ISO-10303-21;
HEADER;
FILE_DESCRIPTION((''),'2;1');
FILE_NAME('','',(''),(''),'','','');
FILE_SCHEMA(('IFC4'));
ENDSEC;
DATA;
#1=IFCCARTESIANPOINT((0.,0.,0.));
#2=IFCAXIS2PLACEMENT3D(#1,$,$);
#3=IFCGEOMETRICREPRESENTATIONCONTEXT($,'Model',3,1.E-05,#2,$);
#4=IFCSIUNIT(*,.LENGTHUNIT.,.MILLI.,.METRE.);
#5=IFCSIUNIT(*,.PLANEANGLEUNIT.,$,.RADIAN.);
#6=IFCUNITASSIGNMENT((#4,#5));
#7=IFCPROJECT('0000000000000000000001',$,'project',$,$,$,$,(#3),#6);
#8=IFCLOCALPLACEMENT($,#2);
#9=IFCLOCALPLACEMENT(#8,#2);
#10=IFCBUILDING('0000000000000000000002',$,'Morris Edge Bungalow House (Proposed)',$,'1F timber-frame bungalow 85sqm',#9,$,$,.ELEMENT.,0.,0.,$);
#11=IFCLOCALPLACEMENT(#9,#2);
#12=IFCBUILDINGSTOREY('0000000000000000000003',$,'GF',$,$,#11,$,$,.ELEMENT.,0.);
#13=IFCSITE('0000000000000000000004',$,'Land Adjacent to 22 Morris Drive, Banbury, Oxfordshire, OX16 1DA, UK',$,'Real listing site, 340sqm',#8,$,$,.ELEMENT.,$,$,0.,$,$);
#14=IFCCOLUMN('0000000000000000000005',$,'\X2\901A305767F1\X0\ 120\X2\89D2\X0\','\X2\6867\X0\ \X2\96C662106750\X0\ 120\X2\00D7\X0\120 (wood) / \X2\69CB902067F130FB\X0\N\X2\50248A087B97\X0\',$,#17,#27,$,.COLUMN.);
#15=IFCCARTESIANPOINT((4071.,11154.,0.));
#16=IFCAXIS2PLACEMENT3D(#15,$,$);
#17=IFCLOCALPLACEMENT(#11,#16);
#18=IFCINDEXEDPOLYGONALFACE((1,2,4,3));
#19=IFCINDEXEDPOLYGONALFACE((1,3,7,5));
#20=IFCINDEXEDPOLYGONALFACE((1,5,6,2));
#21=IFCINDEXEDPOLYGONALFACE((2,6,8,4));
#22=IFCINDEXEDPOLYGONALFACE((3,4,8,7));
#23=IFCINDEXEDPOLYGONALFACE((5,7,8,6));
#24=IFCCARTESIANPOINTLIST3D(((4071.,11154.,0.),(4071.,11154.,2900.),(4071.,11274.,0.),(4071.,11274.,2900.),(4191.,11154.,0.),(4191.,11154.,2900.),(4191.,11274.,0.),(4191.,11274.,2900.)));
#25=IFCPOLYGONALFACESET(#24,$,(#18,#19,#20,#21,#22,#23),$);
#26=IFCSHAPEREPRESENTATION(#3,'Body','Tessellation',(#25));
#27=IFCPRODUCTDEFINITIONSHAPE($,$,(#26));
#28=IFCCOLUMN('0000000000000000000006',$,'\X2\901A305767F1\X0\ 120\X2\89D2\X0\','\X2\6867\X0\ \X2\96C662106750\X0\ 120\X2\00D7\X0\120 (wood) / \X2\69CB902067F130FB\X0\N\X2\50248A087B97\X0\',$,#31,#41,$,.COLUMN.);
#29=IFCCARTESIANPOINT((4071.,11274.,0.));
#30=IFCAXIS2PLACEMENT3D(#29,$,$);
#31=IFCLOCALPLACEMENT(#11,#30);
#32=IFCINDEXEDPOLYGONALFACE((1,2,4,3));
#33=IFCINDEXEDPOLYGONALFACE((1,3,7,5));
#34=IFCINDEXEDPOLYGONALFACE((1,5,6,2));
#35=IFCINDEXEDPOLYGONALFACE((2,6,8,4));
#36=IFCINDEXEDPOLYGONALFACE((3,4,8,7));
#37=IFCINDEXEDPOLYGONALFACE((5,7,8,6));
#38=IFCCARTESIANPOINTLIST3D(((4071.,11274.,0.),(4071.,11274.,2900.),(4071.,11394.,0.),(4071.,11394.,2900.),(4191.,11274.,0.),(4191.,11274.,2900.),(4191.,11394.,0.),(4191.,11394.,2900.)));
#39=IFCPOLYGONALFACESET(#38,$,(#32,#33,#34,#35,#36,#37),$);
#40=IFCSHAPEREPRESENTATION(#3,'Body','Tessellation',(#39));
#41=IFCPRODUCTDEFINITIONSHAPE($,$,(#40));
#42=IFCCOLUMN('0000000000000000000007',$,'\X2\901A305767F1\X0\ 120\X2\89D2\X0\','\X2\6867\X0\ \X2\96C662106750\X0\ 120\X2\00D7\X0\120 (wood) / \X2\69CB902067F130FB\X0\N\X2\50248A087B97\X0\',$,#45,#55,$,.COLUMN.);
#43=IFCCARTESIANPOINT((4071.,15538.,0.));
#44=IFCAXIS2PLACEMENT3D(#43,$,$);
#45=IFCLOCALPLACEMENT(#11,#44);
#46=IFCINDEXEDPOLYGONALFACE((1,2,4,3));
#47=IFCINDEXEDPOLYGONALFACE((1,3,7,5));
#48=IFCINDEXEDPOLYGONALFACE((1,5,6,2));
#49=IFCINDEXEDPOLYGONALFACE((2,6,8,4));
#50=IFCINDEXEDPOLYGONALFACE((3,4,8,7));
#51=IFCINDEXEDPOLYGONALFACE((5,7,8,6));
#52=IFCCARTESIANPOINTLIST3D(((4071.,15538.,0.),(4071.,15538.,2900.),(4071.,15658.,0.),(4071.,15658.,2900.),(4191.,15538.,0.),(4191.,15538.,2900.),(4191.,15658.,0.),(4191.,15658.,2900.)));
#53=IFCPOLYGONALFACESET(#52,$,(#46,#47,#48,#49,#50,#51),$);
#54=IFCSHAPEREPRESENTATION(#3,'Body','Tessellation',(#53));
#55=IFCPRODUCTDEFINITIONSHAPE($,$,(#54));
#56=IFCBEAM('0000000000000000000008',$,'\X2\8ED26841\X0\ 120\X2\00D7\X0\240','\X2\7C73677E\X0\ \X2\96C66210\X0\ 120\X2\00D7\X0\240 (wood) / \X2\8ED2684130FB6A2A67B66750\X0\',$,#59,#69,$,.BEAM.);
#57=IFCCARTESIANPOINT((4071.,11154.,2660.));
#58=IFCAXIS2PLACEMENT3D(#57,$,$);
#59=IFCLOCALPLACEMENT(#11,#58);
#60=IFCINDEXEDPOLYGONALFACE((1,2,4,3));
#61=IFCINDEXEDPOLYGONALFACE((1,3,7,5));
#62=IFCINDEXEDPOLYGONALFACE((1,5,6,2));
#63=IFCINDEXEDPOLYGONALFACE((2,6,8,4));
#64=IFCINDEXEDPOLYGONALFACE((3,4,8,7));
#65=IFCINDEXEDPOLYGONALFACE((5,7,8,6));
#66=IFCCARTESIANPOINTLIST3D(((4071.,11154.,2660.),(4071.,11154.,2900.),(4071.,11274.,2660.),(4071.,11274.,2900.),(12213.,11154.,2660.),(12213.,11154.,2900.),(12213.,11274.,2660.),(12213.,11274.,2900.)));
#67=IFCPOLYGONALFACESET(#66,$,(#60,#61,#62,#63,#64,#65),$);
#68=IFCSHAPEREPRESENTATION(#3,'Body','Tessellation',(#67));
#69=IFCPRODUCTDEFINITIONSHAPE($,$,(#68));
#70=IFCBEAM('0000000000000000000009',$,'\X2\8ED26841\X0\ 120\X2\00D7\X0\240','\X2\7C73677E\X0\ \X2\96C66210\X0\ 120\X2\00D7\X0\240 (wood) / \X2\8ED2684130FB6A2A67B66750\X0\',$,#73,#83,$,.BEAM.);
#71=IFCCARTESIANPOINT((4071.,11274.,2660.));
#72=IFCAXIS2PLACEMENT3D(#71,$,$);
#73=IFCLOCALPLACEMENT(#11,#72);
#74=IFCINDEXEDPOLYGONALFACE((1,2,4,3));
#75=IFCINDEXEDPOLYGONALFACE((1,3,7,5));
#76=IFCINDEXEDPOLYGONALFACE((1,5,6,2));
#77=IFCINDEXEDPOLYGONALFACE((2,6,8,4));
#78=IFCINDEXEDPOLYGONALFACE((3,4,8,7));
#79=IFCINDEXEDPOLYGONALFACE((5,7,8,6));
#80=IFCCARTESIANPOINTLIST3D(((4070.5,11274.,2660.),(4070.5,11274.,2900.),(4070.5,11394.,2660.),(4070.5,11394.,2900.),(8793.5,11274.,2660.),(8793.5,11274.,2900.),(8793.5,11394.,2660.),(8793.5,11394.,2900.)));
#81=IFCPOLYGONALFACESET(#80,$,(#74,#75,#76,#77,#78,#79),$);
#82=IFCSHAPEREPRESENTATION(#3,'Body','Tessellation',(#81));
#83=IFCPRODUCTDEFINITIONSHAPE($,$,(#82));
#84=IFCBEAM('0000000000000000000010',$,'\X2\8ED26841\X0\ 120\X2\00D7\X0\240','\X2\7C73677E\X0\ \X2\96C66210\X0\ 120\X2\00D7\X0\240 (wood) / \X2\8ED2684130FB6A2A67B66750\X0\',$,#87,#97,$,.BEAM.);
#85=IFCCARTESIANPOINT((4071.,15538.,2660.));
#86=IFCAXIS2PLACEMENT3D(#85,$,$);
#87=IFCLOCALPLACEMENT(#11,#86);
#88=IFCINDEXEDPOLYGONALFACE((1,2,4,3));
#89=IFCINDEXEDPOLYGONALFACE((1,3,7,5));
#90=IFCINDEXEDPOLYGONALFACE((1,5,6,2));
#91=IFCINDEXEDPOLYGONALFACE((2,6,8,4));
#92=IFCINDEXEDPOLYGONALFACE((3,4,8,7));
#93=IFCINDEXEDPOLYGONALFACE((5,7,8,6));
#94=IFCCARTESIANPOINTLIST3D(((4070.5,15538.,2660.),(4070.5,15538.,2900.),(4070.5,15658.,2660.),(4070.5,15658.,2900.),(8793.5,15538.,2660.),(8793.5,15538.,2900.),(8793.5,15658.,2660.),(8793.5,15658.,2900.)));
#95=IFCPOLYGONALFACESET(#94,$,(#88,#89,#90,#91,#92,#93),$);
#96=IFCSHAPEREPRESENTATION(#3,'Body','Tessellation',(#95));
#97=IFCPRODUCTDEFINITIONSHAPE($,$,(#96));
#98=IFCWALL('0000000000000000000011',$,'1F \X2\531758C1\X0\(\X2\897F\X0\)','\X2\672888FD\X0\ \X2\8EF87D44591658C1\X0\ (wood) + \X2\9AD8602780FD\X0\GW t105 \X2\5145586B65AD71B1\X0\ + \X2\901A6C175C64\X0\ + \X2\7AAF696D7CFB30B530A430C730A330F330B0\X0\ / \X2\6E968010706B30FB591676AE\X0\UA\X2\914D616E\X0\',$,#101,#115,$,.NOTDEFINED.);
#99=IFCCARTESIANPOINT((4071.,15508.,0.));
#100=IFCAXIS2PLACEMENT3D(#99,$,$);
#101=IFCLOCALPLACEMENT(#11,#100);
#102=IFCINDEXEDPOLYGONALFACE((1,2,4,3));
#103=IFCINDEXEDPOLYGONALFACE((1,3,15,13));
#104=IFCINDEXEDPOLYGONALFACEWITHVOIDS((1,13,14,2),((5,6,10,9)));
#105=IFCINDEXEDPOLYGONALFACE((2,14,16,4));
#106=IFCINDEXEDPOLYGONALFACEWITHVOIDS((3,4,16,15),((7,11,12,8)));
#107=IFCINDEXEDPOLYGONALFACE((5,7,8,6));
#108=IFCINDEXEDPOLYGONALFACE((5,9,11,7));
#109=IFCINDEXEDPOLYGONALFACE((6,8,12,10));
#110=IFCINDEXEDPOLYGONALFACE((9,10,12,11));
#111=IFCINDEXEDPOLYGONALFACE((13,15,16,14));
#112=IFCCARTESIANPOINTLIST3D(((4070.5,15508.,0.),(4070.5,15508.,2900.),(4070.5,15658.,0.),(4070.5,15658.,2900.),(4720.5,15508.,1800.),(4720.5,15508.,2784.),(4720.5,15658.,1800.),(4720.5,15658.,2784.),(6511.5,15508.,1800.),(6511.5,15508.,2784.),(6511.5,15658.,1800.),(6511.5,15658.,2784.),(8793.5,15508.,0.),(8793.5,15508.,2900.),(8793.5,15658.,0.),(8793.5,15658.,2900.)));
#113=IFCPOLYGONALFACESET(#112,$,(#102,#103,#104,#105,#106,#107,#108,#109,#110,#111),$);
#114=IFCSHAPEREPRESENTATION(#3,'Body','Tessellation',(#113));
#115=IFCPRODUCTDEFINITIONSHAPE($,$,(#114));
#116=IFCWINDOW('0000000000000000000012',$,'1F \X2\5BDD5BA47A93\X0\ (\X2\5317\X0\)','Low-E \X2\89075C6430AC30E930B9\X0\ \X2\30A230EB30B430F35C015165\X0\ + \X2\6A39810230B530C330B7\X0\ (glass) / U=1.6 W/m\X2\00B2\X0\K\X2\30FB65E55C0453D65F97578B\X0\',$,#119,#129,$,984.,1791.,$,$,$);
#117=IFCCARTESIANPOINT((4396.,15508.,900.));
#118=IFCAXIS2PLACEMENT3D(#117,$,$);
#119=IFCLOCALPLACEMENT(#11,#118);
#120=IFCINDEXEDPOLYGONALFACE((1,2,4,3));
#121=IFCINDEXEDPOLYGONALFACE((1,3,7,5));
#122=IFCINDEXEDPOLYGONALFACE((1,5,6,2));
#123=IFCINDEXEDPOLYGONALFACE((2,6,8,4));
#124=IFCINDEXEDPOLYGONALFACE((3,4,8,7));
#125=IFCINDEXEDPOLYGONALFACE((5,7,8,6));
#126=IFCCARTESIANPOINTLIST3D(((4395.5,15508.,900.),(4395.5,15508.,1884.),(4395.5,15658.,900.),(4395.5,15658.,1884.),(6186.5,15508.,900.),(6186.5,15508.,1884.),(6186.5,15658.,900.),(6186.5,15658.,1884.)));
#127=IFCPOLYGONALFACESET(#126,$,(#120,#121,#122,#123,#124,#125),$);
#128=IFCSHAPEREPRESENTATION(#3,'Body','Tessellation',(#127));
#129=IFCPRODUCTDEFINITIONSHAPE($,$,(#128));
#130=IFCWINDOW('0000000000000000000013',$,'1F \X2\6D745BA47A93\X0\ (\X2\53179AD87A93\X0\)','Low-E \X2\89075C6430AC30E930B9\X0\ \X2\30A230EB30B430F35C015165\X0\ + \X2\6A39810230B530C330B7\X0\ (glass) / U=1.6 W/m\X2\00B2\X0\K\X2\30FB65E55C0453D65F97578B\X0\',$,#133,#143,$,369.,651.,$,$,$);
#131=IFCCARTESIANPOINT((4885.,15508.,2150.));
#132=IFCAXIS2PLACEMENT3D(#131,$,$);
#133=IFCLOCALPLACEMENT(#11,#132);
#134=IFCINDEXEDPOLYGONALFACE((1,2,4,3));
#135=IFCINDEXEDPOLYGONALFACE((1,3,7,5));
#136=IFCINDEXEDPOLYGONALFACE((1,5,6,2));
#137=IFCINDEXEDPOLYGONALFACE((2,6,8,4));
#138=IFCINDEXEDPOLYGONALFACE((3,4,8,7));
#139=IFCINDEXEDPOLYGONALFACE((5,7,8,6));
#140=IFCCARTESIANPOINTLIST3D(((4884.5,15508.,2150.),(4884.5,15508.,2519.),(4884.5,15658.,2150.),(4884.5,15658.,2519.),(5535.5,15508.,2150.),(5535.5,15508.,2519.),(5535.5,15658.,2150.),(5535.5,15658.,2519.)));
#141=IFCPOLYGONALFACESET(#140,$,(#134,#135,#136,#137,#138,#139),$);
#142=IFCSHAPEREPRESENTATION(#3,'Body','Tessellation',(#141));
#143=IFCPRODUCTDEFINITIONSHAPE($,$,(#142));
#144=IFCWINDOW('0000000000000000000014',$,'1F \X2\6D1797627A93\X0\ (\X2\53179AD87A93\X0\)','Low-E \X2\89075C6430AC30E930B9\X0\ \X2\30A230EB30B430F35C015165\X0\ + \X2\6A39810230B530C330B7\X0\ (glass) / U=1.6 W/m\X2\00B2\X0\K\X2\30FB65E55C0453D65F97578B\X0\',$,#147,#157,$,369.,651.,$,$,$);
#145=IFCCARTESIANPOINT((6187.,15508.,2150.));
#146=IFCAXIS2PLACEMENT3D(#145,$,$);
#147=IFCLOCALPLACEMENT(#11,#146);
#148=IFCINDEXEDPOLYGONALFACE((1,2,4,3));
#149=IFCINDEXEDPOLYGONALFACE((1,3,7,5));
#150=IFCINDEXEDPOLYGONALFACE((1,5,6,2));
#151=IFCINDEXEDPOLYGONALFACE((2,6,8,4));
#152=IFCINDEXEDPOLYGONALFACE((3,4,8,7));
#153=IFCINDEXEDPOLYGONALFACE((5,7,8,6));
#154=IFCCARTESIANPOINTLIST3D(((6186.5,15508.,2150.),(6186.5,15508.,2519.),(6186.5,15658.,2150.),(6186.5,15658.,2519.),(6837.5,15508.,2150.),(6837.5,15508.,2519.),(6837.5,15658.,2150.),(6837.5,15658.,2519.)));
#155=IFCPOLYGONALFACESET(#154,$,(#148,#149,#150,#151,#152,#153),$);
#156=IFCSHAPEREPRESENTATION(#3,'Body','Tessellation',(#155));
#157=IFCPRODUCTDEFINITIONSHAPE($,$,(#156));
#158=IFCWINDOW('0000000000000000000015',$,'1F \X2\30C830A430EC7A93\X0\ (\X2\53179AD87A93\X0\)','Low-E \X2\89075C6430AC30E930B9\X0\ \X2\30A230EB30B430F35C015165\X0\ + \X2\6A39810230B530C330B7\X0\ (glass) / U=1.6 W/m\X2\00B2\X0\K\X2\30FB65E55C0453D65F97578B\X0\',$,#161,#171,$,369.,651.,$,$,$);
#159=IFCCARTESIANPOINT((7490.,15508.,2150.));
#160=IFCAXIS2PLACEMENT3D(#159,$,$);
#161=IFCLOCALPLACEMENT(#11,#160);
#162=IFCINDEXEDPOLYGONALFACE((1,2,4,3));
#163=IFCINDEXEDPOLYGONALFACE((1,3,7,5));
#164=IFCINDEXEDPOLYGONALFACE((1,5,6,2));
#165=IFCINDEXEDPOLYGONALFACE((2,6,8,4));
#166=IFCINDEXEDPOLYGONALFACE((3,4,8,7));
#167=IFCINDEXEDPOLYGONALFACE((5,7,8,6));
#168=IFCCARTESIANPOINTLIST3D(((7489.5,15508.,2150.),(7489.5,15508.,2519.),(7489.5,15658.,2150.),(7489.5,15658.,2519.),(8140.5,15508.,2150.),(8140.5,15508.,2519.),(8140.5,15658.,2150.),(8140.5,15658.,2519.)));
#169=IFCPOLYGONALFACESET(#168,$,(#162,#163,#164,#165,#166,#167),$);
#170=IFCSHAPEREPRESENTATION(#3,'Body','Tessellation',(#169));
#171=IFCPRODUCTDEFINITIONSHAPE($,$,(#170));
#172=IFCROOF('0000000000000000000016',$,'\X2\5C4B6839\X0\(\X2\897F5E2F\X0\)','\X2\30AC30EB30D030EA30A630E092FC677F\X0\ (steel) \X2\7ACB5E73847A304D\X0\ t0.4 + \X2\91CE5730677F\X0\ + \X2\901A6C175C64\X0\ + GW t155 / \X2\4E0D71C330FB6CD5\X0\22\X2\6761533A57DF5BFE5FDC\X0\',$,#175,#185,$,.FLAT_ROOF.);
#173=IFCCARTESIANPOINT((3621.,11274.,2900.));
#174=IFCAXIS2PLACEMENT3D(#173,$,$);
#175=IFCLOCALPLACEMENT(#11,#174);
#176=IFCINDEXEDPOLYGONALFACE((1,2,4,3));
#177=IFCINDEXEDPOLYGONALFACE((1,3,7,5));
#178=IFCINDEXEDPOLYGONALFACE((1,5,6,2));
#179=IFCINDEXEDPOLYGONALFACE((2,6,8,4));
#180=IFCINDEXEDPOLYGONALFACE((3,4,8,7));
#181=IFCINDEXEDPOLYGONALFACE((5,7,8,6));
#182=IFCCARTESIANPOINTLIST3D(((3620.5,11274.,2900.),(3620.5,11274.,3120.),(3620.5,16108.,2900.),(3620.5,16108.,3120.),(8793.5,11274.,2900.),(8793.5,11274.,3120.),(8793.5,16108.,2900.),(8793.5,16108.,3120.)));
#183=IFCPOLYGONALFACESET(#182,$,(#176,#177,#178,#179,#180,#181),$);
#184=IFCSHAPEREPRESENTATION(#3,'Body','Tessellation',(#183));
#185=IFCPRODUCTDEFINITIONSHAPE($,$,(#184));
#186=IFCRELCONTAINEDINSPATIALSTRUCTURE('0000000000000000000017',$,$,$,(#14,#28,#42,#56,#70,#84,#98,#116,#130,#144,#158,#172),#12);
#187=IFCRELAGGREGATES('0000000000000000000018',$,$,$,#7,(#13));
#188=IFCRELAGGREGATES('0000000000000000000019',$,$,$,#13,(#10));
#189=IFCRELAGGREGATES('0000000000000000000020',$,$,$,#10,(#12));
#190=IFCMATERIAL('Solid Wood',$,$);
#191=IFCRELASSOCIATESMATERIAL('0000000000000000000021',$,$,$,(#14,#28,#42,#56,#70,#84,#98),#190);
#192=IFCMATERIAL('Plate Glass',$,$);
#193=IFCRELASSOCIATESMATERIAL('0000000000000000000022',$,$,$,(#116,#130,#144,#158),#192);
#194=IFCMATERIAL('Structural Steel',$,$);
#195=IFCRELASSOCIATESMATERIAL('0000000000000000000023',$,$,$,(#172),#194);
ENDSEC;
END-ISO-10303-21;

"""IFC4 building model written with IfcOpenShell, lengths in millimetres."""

from ifc_helpers import new_model, si_unit, frame, frame_2d, origin, place, context, project, spatial, rectangle, extrude, material, element, fill, save


model = new_model("IFC4")

# Units and contexts
model_context = context("Model", 3, precision=1e-05, world=origin())
ifc_project = project(units=[si_unit("LENGTHUNIT", "METRE", prefix="MILLI"), si_unit("PLANEANGLEUNIT", "RADIAN")], contexts=[model_context])

# Site, building, storey
site_placement = place(None, origin())
site = spatial("IfcSite", under=ifc_project, at=site_placement, Name="Land Adjacent to 22 Morris Drive, Banbury, Oxfordshire, OX16 1DA, UK", ObjectType="Real listing site, 340sqm", CompositionType="ELEMENT", RefElevation=0.0)
building_placement = place(site_placement, origin())
building = spatial("IfcBuilding", under=site, at=building_placement, Name="Morris Edge Bungalow House (Proposed)", ObjectType="1F timber-frame bungalow 85sqm", CompositionType="ELEMENT", ElevationOfRefHeight=0.0, ElevationOfTerrain=0.0)
storey_placement = place(building_placement, origin())
storey = spatial("IfcBuildingStorey", under=building, at=storey_placement, Name="GF", CompositionType="ELEMENT", Elevation=0.0)

# Columns
ifc_material_1 = material(Name="Solid Wood")
column_1_placement = place(storey_placement, frame((4071.0, 11154.0, 0.0)))
element("IfcColumn", 1, at=column_1_placement, inside=storey, material=ifc_material_1, Name="通し柱 120角", Description="桧 集成材 120×120 (wood) / 構造柱・N値計算", PredefinedType="COLUMN", context=model_context, shape_type="SweptSolid", body=[
    extrude(rectangle(XDim=120.0, YDim=120.0, at=frame_2d((60.0, 60.0))), frame((4071.0, 11154.0, 0.0)), (0.0, 0.0, 1.0), 2900.0),
])
column_2_placement = place(storey_placement, frame((4071.0, 11274.0, 0.0)))
element("IfcColumn", 2, at=column_2_placement, inside=storey, material=ifc_material_1, Name="通し柱 120角", Description="桧 集成材 120×120 (wood) / 構造柱・N値計算", PredefinedType="COLUMN", context=model_context, shape_type="SweptSolid", body=[
    extrude(rectangle(XDim=120.0, YDim=120.0, at=frame_2d((60.0, 60.0))), frame((4071.0, 11274.0, 0.0)), (0.0, 0.0, 1.0), 2900.0),
])
column_3_placement = place(storey_placement, frame((4071.0, 15538.0, 0.0)))
element("IfcColumn", 3, at=column_3_placement, inside=storey, material=ifc_material_1, Name="通し柱 120角", Description="桧 集成材 120×120 (wood) / 構造柱・N値計算", PredefinedType="COLUMN", context=model_context, shape_type="SweptSolid", body=[
    extrude(rectangle(XDim=120.0, YDim=120.0, at=frame_2d((60.0, 60.0))), frame((4071.0, 15538.0, 0.0)), (0.0, 0.0, 1.0), 2900.0),
])

# Beams
beam_1_placement = place(storey_placement, frame((4071.0, 11154.0, 2660.0)))
element("IfcBeam", 4, at=beam_1_placement, inside=storey, material=ifc_material_1, Name="軒桁 120×240", Description="米松 集成 120×240 (wood) / 軒桁・横架材", PredefinedType="BEAM", context=model_context, shape_type="SweptSolid", body=[
    extrude(rectangle(XDim=8142.0, YDim=120.0, at=frame_2d((4071.0, 60.0))), frame((4071.0, 11154.0, 2660.0)), (0.0, 0.0, 1.0), 240.0),
])
beam_2_placement = place(storey_placement, frame((4071.0, 11274.0, 2660.0)))
element("IfcBeam", 5, at=beam_2_placement, inside=storey, material=ifc_material_1, Name="軒桁 120×240", Description="米松 集成 120×240 (wood) / 軒桁・横架材", PredefinedType="BEAM", context=model_context, shape_type="SweptSolid", body=[
    extrude(rectangle(XDim=4723.0, YDim=120.0, at=frame_2d((2361.0, 60.0))), frame((4071.0, 11274.0, 2660.0)), (0.0, 0.0, 1.0), 240.0),
])
beam_3_placement = place(storey_placement, frame((4071.0, 15538.0, 2660.0)))
element("IfcBeam", 6, at=beam_3_placement, inside=storey, material=ifc_material_1, Name="軒桁 120×240", Description="米松 集成 120×240 (wood) / 軒桁・横架材", PredefinedType="BEAM", context=model_context, shape_type="SweptSolid", body=[
    extrude(rectangle(XDim=4723.0, YDim=120.0, at=frame_2d((2361.0, 60.0))), frame((4071.0, 15538.0, 2660.0)), (0.0, 0.0, 1.0), 240.0),
])

# Wall, openings, windows
wall_1_placement = place(storey_placement, frame((4071.0, 15508.0, 0.0)))
wall_1 = element("IfcWall", 7, at=wall_1_placement, inside=storey, material=ifc_material_1, Name="1F 北壁(西)", Description="木製 軸組外壁 (wood) + 高性能GW t105 充填断熱 + 通気層 + 窯業系サイディング / 準耐火・外皮UA配慮", PredefinedType="NOTDEFINED", context=model_context, shape_type="SweptSolid", body=[
    extrude(rectangle(XDim=4723.0, YDim=150.0, at=frame_2d((2361.0, 75.0))), frame((4071.0, 15508.0, 0.0)), (0.0, 0.0, 1.0), 2900.0),
])
opening_1_placement = place(storey_placement, frame((4396.0, 15508.0, 900.0)))
opening_1 = element("IfcOpeningElement", 8, at=opening_1_placement, cuts=wall_1, PredefinedType="NOTDEFINED", context=model_context, shape_type="SweptSolid", body=[
    extrude(rectangle(XDim=1791.0, YDim=150.0, at=frame_2d((895.0, 75.0))), frame((4396.0, 15508.0, 900.0)), (0.0, 0.0, 1.0), 984.0),
])
opening_2_placement = place(storey_placement, frame((4885.0, 15508.0, 2150.0)))
opening_2 = element("IfcOpeningElement", 9, at=opening_2_placement, cuts=wall_1, PredefinedType="NOTDEFINED", context=model_context, shape_type="SweptSolid", body=[
    extrude(rectangle(XDim=651.0, YDim=150.0, at=frame_2d((325.0, 75.0))), frame((4885.0, 15508.0, 2150.0)), (0.0, 0.0, 1.0), 369.0),
])
opening_3_placement = place(storey_placement, frame((6187.0, 15508.0, 2150.0)))
opening_3 = element("IfcOpeningElement", 10, at=opening_3_placement, cuts=wall_1, PredefinedType="NOTDEFINED", context=model_context, shape_type="SweptSolid", body=[
    extrude(rectangle(XDim=651.0, YDim=150.0, at=frame_2d((325.0, 75.0))), frame((6187.0, 15508.0, 2150.0)), (0.0, 0.0, 1.0), 369.0),
])
opening_4_placement = place(storey_placement, frame((7490.0, 15508.0, 2150.0)))
opening_4 = element("IfcOpeningElement", 11, at=opening_4_placement, cuts=wall_1, PredefinedType="NOTDEFINED", context=model_context, shape_type="SweptSolid", body=[
    extrude(rectangle(XDim=651.0, YDim=150.0, at=frame_2d((325.0, 75.0))), frame((7490.0, 15508.0, 2150.0)), (0.0, 0.0, 1.0), 369.0),
])
ifc_material_2 = material(Name="Plate Glass")
window_1_placement = place(storey_placement, frame((4396.0, 15508.0, 900.0)))
window_1 = element("IfcWindow", 12, at=window_1_placement, inside=storey, material=ifc_material_2, Name="1F 寝室窓 (北)", Description="Low-E 複層ガラス アルゴン封入 + 樹脂サッシ (glass) / U=1.6 W/m²K・日射取得型", OverallHeight=984.0, OverallWidth=1791.0, context=model_context, shape_type="SweptSolid", body=[
    extrude(rectangle(XDim=1791.0, YDim=150.0, at=frame_2d((895.0, 75.0))), frame((4396.0, 15508.0, 900.0)), (0.0, 0.0, 1.0), 984.0),
])
fill(opening_1, window_1)
window_2_placement = place(storey_placement, frame((4885.0, 15508.0, 2150.0)))
window_2 = element("IfcWindow", 13, at=window_2_placement, inside=storey, material=ifc_material_2, Name="1F 浴室窓 (北高窓)", Description="Low-E 複層ガラス アルゴン封入 + 樹脂サッシ (glass) / U=1.6 W/m²K・日射取得型", OverallHeight=369.0, OverallWidth=651.0, context=model_context, shape_type="SweptSolid", body=[
    extrude(rectangle(XDim=651.0, YDim=150.0, at=frame_2d((325.0, 75.0))), frame((4885.0, 15508.0, 2150.0)), (0.0, 0.0, 1.0), 369.0),
])
fill(opening_2, window_2)
window_3_placement = place(storey_placement, frame((6187.0, 15508.0, 2150.0)))
window_3 = element("IfcWindow", 14, at=window_3_placement, inside=storey, material=ifc_material_2, Name="1F 洗面窓 (北高窓)", Description="Low-E 複層ガラス アルゴン封入 + 樹脂サッシ (glass) / U=1.6 W/m²K・日射取得型", OverallHeight=369.0, OverallWidth=651.0, context=model_context, shape_type="SweptSolid", body=[
    extrude(rectangle(XDim=651.0, YDim=150.0, at=frame_2d((325.0, 75.0))), frame((6187.0, 15508.0, 2150.0)), (0.0, 0.0, 1.0), 369.0),
])
fill(opening_3, window_3)
window_4_placement = place(storey_placement, frame((7490.0, 15508.0, 2150.0)))
window_4 = element("IfcWindow", 15, at=window_4_placement, inside=storey, material=ifc_material_2, Name="1F トイレ窓 (北高窓)", Description="Low-E 複層ガラス アルゴン封入 + 樹脂サッシ (glass) / U=1.6 W/m²K・日射取得型", OverallHeight=369.0, OverallWidth=651.0, context=model_context, shape_type="SweptSolid", body=[
    extrude(rectangle(XDim=651.0, YDim=150.0, at=frame_2d((325.0, 75.0))), frame((7490.0, 15508.0, 2150.0)), (0.0, 0.0, 1.0), 369.0),
])
fill(opening_4, window_4)

# Roof
ifc_material_3 = material(Name="Structural Steel")
roof_placement = place(storey_placement, frame((3621.0, 11274.0, 2900.0)))
element("IfcRoof", 16, at=roof_placement, inside=storey, material=ifc_material_3, Name="屋根(西帯)", Description="ガルバリウム鋼板 (steel) 立平葺き t0.4 + 野地板 + 通気層 + GW t155 / 不燃・法22条区域対応", PredefinedType="FLAT_ROOF", context=model_context, shape_type="SweptSolid", body=[
    extrude(rectangle(XDim=5173.0, YDim=4834.0, at=frame_2d((2586.0, 2417.0))), frame((3621.0, 11274.0, 2900.0)), (0.0, 0.0, 1.0), 220.0),
])

save(model, "model.ifc")
